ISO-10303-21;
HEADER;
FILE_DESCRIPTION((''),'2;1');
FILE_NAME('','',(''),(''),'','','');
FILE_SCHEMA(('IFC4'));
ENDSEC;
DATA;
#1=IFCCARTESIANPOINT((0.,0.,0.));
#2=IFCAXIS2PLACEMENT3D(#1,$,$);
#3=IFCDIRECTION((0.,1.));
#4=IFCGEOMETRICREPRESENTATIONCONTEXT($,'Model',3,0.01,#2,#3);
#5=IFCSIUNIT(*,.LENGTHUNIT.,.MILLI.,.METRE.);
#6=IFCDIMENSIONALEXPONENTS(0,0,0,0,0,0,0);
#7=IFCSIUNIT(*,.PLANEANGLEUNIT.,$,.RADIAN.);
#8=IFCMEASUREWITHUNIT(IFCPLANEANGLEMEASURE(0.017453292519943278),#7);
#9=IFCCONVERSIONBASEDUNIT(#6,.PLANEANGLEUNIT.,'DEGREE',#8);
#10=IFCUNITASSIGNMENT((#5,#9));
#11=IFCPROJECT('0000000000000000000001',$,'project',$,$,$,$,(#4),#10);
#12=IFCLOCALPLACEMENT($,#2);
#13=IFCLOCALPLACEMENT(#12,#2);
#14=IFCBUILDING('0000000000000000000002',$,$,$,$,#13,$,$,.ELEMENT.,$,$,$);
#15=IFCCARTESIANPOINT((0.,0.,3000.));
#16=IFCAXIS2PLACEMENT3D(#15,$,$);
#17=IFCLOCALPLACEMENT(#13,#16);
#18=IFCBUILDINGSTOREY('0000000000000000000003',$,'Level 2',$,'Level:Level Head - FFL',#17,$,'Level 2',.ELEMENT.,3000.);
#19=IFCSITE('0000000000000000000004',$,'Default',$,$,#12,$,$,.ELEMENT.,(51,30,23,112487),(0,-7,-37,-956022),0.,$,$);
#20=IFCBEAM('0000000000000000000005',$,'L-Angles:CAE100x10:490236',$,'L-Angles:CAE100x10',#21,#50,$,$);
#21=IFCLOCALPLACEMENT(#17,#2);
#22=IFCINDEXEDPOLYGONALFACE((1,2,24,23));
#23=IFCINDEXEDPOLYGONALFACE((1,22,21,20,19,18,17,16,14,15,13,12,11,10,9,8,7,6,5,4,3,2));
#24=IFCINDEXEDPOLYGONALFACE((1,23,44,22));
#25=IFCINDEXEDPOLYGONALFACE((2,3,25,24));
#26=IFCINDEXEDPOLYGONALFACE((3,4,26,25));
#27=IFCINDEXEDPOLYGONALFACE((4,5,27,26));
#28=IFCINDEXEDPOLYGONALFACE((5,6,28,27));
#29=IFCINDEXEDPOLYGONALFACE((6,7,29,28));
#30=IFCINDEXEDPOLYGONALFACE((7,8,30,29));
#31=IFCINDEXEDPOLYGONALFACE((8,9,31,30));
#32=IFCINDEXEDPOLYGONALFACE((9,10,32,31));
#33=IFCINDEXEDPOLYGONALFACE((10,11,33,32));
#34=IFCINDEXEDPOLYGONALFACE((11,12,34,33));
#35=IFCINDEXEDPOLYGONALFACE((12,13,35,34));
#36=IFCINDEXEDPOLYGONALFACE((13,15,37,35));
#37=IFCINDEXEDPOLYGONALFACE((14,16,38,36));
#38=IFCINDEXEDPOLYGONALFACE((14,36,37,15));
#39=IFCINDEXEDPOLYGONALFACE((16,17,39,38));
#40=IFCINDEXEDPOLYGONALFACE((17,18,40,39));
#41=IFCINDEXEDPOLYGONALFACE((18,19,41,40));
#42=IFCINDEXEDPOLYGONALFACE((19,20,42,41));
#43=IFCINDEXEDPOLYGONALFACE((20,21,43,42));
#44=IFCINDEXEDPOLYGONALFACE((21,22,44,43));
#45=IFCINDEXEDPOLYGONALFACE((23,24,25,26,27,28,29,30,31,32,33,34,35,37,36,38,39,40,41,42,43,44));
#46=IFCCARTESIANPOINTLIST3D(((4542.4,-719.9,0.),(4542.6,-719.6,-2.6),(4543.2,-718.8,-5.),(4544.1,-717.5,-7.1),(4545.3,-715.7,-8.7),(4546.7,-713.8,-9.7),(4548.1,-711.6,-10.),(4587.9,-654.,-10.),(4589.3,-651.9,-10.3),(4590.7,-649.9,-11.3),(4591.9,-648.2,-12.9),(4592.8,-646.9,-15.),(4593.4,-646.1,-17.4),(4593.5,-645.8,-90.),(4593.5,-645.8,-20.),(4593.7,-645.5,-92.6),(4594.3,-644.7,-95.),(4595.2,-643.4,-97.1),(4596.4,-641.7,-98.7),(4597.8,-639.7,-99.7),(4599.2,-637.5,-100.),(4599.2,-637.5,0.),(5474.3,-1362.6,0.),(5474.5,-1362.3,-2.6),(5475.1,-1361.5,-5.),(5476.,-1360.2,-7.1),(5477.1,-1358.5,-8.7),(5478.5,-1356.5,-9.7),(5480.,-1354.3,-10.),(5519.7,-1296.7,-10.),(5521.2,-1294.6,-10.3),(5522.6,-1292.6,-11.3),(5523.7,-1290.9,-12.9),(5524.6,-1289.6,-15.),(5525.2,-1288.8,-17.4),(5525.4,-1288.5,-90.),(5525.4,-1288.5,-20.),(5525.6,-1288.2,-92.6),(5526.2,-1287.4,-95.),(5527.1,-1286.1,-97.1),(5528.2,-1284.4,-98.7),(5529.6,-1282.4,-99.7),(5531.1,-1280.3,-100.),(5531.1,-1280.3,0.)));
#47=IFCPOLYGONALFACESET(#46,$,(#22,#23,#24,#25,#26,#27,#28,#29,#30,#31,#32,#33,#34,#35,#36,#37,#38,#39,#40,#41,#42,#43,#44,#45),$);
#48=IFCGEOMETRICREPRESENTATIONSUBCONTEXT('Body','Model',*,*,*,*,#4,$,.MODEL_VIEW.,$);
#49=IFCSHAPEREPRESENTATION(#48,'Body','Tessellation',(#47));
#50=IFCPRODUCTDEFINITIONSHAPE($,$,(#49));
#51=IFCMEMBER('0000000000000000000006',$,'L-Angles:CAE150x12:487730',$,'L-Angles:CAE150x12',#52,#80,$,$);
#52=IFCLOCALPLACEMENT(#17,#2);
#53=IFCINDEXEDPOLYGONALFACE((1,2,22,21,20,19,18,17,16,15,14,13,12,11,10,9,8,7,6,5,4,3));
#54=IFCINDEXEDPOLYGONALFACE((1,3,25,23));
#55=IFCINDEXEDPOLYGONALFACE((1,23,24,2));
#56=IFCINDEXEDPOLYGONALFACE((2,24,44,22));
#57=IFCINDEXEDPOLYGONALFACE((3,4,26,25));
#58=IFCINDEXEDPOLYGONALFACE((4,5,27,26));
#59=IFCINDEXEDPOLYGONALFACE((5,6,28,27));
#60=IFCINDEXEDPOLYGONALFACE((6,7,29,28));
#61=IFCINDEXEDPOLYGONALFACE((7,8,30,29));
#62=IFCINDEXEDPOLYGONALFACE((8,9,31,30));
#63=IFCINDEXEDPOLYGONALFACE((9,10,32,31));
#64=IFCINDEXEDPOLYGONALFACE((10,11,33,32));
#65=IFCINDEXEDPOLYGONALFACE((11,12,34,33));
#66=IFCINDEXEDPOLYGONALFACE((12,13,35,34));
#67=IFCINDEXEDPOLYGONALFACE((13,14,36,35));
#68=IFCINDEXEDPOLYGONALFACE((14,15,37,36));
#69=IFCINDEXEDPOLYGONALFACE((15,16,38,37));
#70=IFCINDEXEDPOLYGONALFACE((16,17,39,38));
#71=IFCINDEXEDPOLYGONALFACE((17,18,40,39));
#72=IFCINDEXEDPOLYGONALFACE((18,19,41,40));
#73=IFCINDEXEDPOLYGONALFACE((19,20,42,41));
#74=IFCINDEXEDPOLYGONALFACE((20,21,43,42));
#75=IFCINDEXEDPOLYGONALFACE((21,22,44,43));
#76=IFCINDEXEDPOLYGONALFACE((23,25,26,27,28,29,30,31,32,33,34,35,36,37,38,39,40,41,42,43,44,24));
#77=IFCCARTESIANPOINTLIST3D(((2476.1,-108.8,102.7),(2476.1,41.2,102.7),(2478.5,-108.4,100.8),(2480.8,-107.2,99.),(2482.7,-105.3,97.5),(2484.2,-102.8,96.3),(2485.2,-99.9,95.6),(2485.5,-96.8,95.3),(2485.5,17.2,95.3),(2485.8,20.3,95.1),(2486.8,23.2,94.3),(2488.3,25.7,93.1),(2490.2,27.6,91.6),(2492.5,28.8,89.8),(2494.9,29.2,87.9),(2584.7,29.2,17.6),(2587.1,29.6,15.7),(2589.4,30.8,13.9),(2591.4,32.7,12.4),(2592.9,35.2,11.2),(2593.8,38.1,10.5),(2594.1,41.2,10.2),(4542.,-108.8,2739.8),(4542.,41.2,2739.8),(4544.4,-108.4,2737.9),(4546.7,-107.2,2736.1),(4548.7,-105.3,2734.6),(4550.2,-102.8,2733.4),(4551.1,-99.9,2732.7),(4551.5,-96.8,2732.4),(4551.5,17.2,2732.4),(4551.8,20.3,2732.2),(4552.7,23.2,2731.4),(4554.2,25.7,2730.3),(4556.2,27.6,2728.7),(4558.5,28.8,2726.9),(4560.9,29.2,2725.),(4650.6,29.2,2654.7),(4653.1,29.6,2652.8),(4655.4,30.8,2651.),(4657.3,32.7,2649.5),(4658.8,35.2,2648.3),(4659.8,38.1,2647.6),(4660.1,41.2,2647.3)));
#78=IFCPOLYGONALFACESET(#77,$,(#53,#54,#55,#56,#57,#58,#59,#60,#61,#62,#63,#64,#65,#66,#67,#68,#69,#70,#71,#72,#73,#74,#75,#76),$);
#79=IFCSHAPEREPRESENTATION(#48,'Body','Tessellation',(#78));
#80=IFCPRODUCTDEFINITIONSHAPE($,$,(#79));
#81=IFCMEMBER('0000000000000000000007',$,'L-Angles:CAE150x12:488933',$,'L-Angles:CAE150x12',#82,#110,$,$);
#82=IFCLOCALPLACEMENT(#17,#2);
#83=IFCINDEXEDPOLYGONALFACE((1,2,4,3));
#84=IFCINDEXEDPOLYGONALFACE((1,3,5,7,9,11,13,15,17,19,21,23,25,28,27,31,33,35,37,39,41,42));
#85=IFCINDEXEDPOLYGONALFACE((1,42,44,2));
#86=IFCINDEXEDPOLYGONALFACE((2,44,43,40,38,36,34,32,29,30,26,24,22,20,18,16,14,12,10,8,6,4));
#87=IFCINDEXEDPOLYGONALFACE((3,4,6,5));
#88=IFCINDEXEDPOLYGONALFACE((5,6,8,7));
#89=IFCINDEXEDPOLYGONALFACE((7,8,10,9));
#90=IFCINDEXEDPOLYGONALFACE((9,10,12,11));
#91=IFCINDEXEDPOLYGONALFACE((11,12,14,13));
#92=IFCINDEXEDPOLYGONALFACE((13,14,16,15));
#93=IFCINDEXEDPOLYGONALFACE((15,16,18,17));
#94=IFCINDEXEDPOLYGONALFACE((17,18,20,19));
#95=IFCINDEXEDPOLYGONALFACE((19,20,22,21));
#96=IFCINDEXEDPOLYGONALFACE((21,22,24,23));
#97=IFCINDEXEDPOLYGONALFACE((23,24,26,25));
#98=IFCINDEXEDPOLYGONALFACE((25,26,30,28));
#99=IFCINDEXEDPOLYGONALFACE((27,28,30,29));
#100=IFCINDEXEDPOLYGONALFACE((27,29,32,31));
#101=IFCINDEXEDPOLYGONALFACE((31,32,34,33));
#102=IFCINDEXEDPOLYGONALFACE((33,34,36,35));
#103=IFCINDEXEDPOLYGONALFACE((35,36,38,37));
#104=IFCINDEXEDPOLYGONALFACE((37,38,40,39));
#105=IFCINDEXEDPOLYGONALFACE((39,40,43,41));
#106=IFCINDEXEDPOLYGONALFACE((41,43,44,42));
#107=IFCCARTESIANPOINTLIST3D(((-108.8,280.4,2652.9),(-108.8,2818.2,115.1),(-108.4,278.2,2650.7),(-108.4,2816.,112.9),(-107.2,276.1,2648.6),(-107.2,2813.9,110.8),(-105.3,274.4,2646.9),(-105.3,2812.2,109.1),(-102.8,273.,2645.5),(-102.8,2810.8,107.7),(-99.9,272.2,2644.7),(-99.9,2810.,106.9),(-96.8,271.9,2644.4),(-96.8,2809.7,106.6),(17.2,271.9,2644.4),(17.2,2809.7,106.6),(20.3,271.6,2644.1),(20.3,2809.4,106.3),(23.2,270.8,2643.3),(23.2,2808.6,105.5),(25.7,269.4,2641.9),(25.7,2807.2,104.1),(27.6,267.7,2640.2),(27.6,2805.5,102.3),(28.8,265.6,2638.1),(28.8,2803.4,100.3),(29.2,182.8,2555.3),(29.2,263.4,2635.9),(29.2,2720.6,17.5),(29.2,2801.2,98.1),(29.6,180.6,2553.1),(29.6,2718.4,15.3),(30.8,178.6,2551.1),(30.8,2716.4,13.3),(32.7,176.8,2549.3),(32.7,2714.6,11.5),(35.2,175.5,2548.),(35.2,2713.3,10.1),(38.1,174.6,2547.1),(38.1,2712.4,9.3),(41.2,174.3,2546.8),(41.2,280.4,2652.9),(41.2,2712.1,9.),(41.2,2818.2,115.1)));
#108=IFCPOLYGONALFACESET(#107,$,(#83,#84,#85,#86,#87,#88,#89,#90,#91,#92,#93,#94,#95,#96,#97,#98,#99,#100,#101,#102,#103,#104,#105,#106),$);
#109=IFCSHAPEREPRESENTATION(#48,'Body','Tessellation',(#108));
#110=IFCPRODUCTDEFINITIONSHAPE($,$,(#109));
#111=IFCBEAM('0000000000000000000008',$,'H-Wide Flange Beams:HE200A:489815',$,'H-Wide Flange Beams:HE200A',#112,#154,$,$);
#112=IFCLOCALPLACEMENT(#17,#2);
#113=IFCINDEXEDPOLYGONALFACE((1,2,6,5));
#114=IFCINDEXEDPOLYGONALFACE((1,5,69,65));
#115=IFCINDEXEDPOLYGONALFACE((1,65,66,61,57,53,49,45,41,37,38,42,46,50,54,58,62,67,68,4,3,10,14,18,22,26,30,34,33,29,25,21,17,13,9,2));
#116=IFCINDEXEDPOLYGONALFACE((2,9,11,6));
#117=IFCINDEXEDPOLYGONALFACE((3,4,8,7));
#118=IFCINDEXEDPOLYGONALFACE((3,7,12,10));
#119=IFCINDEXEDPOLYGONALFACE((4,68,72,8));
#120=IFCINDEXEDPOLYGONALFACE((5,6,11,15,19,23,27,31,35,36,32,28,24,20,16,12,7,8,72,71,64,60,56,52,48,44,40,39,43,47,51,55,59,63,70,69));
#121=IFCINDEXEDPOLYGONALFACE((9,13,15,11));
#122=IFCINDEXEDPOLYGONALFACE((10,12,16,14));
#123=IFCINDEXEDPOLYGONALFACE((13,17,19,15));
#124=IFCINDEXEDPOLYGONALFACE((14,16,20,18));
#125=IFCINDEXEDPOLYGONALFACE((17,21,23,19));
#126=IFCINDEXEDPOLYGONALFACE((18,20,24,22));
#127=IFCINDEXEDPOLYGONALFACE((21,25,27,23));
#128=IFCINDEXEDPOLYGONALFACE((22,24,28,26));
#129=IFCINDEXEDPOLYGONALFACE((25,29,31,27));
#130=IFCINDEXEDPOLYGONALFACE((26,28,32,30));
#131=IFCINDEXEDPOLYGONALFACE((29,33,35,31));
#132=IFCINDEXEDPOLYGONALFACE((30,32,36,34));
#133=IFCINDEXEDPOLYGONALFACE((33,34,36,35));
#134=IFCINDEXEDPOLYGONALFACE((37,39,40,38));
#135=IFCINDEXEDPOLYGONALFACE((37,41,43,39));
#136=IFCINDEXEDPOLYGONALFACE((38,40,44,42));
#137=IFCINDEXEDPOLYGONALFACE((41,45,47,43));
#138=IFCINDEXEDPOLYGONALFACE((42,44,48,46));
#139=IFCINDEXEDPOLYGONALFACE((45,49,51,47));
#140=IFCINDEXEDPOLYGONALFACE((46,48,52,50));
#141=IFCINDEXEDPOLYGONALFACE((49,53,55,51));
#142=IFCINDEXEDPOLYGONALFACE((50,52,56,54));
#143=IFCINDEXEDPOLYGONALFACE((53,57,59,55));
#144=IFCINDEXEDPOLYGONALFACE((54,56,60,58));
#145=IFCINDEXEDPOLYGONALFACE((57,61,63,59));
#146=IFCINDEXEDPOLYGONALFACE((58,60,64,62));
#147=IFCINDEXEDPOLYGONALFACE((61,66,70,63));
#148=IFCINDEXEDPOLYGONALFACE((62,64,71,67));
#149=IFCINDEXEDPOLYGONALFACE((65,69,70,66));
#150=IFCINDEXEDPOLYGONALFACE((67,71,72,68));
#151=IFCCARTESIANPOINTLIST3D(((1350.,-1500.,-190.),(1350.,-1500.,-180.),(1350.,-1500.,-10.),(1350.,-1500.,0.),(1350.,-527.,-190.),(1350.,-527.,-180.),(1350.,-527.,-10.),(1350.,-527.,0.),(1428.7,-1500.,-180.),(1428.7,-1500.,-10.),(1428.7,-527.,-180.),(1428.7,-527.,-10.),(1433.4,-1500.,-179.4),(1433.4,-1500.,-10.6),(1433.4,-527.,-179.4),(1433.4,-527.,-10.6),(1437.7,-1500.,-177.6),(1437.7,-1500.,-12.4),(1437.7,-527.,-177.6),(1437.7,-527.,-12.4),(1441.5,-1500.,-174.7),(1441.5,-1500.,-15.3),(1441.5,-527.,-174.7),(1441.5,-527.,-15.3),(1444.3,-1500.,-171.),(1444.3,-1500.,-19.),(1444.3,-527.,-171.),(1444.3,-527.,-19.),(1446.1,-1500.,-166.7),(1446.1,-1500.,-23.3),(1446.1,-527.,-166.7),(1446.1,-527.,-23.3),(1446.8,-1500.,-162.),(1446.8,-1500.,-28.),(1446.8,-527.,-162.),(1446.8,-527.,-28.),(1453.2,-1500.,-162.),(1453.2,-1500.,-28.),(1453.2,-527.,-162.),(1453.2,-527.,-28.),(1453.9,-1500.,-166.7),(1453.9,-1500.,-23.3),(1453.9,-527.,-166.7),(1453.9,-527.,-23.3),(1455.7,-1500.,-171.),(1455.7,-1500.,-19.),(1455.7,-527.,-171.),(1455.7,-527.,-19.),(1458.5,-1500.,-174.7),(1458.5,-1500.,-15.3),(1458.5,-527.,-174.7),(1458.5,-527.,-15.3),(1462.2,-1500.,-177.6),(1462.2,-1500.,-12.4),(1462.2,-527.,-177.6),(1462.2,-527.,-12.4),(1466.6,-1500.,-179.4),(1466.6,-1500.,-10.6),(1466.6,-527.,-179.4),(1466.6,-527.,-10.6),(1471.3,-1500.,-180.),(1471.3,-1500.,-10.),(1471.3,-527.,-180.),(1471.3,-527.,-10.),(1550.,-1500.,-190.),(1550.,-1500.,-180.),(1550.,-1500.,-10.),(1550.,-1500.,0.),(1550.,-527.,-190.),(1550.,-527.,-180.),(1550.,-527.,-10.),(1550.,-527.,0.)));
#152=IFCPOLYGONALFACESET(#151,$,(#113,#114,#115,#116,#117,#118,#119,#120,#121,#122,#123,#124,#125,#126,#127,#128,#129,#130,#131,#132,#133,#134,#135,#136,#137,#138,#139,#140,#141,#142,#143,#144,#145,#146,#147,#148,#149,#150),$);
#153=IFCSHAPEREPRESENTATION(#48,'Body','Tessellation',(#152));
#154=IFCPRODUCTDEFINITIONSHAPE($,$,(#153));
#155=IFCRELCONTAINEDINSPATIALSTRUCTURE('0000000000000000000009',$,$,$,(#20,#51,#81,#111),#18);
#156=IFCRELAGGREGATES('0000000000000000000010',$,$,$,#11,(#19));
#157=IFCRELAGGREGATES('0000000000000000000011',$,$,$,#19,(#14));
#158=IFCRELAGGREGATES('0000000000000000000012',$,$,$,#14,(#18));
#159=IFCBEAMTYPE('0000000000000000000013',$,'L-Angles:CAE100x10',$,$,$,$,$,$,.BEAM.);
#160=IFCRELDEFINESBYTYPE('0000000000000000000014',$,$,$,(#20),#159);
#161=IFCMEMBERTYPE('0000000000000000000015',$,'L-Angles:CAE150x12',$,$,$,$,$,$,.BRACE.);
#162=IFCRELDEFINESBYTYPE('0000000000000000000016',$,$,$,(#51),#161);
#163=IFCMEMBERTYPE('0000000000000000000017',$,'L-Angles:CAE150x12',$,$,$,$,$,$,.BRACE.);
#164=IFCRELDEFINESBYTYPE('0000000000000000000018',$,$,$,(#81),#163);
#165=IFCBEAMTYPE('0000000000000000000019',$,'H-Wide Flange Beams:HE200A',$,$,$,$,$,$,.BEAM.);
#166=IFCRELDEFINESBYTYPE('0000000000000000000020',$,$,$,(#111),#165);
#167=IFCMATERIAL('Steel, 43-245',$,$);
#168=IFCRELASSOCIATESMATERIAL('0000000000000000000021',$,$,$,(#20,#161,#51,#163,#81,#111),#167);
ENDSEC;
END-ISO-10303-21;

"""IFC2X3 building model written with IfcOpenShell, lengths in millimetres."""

from ifc_helpers import new_model, entity, si_unit, converted_unit, direction, frame, frame_2d, origin, place, context, subcontext, project, spatial, polyline, circle_curve, parameter, trimmed, segment, composite_curve, i_section, outline, extrude, source, transform, mapped, material, type_object, type_shapes, element, save


model = new_model("IFC2X3")

# Units and contexts
model_context = context("Model", 3, precision=0.01, world=origin(), true_north=direction((0.0, 1.0)))
body_context = subcontext(model_context, "Body", "Model", "MODEL_VIEW")
ifc_project = project(units=[si_unit("LENGTHUNIT", "METRE", prefix="MILLI"), converted_unit("PLANEANGLEUNIT", "DEGREE", entity("IfcPlaneAngleMeasure", 0.017453292519943278), si_unit("PLANEANGLEUNIT", "RADIAN"), dimensions=[0, 0, 0, 0, 0, 0, 0])], contexts=[model_context])

# Site, building, storey
site_placement = place(None, origin())
site = spatial("IfcSite", under=ifc_project, at=site_placement, Name="Default", CompositionType="ELEMENT", RefLatitude=(51, 30, 23, 112487), RefLongitude=(0, -7, -37, -956022), RefElevation=0.0)
building_placement = place(site_placement, origin())
building = spatial("IfcBuilding", under=site, at=building_placement, CompositionType="ELEMENT")
storey_placement = place(building_placement, frame((0.0, 0.0, 3000.0)))
storey = spatial("IfcBuildingStorey", under=building, at=storey_placement, Name="Level 2", ObjectType="Level:Level Head - FFL", LongName="Level 2", CompositionType="ELEMENT", Elevation=3000.0)

# Beam
ifc_material = material(Name="Steel, 43-245")
beam_type_1 = type_object("IfcBeamType", Name="L-Angles:CAE100x10", PredefinedType="BEAM")
beam_1_placement = place(storey_placement, frame((4350.1, -500.0, 0.0), z_axis=(0.0, 0.0, 1.0), x_axis=(0.823188, -0.567769, 0.0)))
element("IfcBeam", 1, at=beam_1_placement, inside=storey, type_object=beam_type_1, material=ifc_material, Name="L-Angles:CAE100x10:490236", ObjectType="L-Angles:CAE100x10", context=body_context, shape_type="SweptSolid", body=[
    extrude(outline(composite_curve([segment(polyline([(-67.1, -32.9), (32.9, -32.9)]), True, "CONTINUOUS"), segment(polyline([(32.9, -32.9), (32.9, 67.1)]), True, "CONTINUOUS"), segment(trimmed(circle_curve(frame_2d((32.9, 57.1), x_axis=(0.0, 1.0)), 10.0), [parameter(0.0)], [parameter(90.0)], True, "PARAMETER"), True, "CONTINUOUS"), segment(polyline([(22.9, 57.1), (22.9, -12.9)]), True, "CONTINUOUS"), segment(trimmed(circle_curve(frame_2d((12.9, -12.9), x_axis=(1.0, 0.0)), 10.0), [parameter(270.0)], [parameter(0.0)], True, "PARAMETER"), False, "CONTINUOUS"), segment(polyline([(12.9, -22.9), (-57.1, -22.9)]), True, "CONTINUOUS"), segment(trimmed(circle_curve(frame_2d((-57.1, -32.9), x_axis=(0.0, 1.0)), 10.0), [parameter(0.0)], [parameter(90.0)], True, "PARAMETER"), True, "CONTINUOUS")], self_intersect=False)), frame((283.1, -4.7, -32.9), z_axis=(1.0, 0.0, 0.0), x_axis=(0.0, 0.0, 1.0)), (0.0, 0.0, 1.0), 1132.0),
])

# Members
member_type_1 = type_object("IfcMemberType", Name="L-Angles:CAE150x12", PredefinedType="BRACE", material=ifc_material)
shared_shape_1 = source(origin(), body_context, "Body", "SweptSolid", [
    extrude(outline(composite_curve([segment(polyline([(-102.0, -48.0), (48.0, -48.0)]), True, "CONTINUOUS"), segment(polyline([(48.0, -48.0), (48.0, 102.0)]), True, "CONTINUOUS"), segment(trimmed(circle_curve(frame_2d((48.0, 90.0), x_axis=(0.0, 1.0)), 12.0), [parameter(0.0)], [parameter(90.0)], True, "PARAMETER"), True, "CONTINUOUS"), segment(polyline([(36.0, 90.0), (36.0, -24.0)]), True, "CONTINUOUS"), segment(trimmed(circle_curve(frame_2d((24.0, -24.0), x_axis=(1.0, 0.0)), 12.0), [parameter(270.0)], [parameter(0.0)], True, "PARAMETER"), False, "CONTINUOUS"), segment(polyline([(24.0, -36.0), (-90.0, -36.0)]), True, "CONTINUOUS"), segment(trimmed(circle_curve(frame_2d((-90.0, -48.0), x_axis=(0.0, 1.0)), 12.0), [parameter(0.0)], [parameter(90.0)], True, "PARAMETER"), True, "CONTINUOUS")], self_intersect=False)), frame((-1648.5, -6.8, -6.8), z_axis=(1.0, 0.0, 0.0), x_axis=(0.0, 0.0, 1.0)), (0.0, 0.0, 1.0), 3350.0),
])
type_shapes(member_type_1, [shared_shape_1])
member_1_placement = place(storey_placement, frame((3525.1, 0.0, 1375.0), z_axis=(-0.787197, 0.0, 0.616701), x_axis=(0.616701, 0.0, 0.787197)))
element("IfcMember", 2, at=member_1_placement, inside=storey, type_object=member_type_1, material=ifc_material, Name="L-Angles:CAE150x12:487730", ObjectType="L-Angles:CAE150x12", context=body_context, shape_type="MappedRepresentation", body=[
    mapped(shared_shape_1, transform((0.0, 0.0, 0.0), scale=1.0)),
])
member_type_2 = type_object("IfcMemberType", Name="L-Angles:CAE150x12", PredefinedType="BRACE", material=ifc_material)
shared_shape_2 = source(origin(), body_context, "Body", "SweptSolid", [
    extrude(outline(composite_curve([segment(polyline([(-102.0, -48.0), (48.0, -48.0)]), True, "CONTINUOUS"), segment(polyline([(48.0, -48.0), (48.0, 102.0)]), True, "CONTINUOUS"), segment(trimmed(circle_curve(frame_2d((48.0, 90.0), x_axis=(0.0, 1.0)), 12.0), [parameter(0.0)], [parameter(90.0)], True, "PARAMETER"), True, "CONTINUOUS"), segment(polyline([(36.0, 90.0), (36.0, -24.0)]), True, "CONTINUOUS"), segment(trimmed(circle_curve(frame_2d((24.0, -24.0), x_axis=(1.0, 0.0)), 12.0), [parameter(270.0)], [parameter(0.0)], True, "PARAMETER"), False, "CONTINUOUS"), segment(polyline([(24.0, -36.0), (-90.0, -36.0)]), True, "CONTINUOUS"), segment(trimmed(circle_curve(frame_2d((-90.0, -48.0), x_axis=(0.0, 1.0)), 12.0), [parameter(0.0)], [parameter(90.0)], True, "PARAMETER"), True, "CONTINUOUS")], self_intersect=False)), frame((-1823.0, -6.8, -6.8), z_axis=(1.0, 0.0, 0.0), x_axis=(0.0, 0.0, 1.0)), (0.0, 0.0, 1.0), 3589.0),
])
type_shapes(member_type_2, [shared_shape_2])
member_2_placement = place(storey_placement, frame((0.0, 1500.0, 1375.0), z_axis=(0.0, 0.707107, 0.707107), x_axis=(0.0, -0.707107, 0.707107)))
element("IfcMember", 3, at=member_2_placement, inside=storey, type_object=member_type_2, material=ifc_material, Name="L-Angles:CAE150x12:488933", ObjectType="L-Angles:CAE150x12", context=body_context, shape_type="MappedRepresentation", body=[
    mapped(shared_shape_2, transform((0.0, 0.0, 0.0), scale=1.0)),
])

# Beam
beam_type_2 = type_object("IfcBeamType", Name="H-Wide Flange Beams:HE200A", PredefinedType="BEAM")
beam_2_placement = place(storey_placement, frame((1450.0, -1500.0, 0.0), z_axis=(0.0, 0.0, 1.0), x_axis=(0.0, 1.0, 0.0)))
element("IfcBeam", 4, at=beam_2_placement, inside=storey, type_object=beam_type_2, material=ifc_material, Name="H-Wide Flange Beams:HE200A:489815", ObjectType="H-Wide Flange Beams:HE200A", context=body_context, shape_type="SweptSolid", body=[
    extrude(i_section(OverallWidth=200.0, OverallDepth=190.0, WebThickness=6.5, FlangeThickness=10.0, FilletRadius=18.0, at=frame_2d((0.0, 0.0), x_axis=(0.0, 1.0))), frame((0.0, 0.0, -95.0), z_axis=(1.0, 0.0, 0.0), x_axis=(0.0, 0.0, -1.0)), (0.0, 0.0, 1.0), 973.0),
])

save(model, "model.ifc")
